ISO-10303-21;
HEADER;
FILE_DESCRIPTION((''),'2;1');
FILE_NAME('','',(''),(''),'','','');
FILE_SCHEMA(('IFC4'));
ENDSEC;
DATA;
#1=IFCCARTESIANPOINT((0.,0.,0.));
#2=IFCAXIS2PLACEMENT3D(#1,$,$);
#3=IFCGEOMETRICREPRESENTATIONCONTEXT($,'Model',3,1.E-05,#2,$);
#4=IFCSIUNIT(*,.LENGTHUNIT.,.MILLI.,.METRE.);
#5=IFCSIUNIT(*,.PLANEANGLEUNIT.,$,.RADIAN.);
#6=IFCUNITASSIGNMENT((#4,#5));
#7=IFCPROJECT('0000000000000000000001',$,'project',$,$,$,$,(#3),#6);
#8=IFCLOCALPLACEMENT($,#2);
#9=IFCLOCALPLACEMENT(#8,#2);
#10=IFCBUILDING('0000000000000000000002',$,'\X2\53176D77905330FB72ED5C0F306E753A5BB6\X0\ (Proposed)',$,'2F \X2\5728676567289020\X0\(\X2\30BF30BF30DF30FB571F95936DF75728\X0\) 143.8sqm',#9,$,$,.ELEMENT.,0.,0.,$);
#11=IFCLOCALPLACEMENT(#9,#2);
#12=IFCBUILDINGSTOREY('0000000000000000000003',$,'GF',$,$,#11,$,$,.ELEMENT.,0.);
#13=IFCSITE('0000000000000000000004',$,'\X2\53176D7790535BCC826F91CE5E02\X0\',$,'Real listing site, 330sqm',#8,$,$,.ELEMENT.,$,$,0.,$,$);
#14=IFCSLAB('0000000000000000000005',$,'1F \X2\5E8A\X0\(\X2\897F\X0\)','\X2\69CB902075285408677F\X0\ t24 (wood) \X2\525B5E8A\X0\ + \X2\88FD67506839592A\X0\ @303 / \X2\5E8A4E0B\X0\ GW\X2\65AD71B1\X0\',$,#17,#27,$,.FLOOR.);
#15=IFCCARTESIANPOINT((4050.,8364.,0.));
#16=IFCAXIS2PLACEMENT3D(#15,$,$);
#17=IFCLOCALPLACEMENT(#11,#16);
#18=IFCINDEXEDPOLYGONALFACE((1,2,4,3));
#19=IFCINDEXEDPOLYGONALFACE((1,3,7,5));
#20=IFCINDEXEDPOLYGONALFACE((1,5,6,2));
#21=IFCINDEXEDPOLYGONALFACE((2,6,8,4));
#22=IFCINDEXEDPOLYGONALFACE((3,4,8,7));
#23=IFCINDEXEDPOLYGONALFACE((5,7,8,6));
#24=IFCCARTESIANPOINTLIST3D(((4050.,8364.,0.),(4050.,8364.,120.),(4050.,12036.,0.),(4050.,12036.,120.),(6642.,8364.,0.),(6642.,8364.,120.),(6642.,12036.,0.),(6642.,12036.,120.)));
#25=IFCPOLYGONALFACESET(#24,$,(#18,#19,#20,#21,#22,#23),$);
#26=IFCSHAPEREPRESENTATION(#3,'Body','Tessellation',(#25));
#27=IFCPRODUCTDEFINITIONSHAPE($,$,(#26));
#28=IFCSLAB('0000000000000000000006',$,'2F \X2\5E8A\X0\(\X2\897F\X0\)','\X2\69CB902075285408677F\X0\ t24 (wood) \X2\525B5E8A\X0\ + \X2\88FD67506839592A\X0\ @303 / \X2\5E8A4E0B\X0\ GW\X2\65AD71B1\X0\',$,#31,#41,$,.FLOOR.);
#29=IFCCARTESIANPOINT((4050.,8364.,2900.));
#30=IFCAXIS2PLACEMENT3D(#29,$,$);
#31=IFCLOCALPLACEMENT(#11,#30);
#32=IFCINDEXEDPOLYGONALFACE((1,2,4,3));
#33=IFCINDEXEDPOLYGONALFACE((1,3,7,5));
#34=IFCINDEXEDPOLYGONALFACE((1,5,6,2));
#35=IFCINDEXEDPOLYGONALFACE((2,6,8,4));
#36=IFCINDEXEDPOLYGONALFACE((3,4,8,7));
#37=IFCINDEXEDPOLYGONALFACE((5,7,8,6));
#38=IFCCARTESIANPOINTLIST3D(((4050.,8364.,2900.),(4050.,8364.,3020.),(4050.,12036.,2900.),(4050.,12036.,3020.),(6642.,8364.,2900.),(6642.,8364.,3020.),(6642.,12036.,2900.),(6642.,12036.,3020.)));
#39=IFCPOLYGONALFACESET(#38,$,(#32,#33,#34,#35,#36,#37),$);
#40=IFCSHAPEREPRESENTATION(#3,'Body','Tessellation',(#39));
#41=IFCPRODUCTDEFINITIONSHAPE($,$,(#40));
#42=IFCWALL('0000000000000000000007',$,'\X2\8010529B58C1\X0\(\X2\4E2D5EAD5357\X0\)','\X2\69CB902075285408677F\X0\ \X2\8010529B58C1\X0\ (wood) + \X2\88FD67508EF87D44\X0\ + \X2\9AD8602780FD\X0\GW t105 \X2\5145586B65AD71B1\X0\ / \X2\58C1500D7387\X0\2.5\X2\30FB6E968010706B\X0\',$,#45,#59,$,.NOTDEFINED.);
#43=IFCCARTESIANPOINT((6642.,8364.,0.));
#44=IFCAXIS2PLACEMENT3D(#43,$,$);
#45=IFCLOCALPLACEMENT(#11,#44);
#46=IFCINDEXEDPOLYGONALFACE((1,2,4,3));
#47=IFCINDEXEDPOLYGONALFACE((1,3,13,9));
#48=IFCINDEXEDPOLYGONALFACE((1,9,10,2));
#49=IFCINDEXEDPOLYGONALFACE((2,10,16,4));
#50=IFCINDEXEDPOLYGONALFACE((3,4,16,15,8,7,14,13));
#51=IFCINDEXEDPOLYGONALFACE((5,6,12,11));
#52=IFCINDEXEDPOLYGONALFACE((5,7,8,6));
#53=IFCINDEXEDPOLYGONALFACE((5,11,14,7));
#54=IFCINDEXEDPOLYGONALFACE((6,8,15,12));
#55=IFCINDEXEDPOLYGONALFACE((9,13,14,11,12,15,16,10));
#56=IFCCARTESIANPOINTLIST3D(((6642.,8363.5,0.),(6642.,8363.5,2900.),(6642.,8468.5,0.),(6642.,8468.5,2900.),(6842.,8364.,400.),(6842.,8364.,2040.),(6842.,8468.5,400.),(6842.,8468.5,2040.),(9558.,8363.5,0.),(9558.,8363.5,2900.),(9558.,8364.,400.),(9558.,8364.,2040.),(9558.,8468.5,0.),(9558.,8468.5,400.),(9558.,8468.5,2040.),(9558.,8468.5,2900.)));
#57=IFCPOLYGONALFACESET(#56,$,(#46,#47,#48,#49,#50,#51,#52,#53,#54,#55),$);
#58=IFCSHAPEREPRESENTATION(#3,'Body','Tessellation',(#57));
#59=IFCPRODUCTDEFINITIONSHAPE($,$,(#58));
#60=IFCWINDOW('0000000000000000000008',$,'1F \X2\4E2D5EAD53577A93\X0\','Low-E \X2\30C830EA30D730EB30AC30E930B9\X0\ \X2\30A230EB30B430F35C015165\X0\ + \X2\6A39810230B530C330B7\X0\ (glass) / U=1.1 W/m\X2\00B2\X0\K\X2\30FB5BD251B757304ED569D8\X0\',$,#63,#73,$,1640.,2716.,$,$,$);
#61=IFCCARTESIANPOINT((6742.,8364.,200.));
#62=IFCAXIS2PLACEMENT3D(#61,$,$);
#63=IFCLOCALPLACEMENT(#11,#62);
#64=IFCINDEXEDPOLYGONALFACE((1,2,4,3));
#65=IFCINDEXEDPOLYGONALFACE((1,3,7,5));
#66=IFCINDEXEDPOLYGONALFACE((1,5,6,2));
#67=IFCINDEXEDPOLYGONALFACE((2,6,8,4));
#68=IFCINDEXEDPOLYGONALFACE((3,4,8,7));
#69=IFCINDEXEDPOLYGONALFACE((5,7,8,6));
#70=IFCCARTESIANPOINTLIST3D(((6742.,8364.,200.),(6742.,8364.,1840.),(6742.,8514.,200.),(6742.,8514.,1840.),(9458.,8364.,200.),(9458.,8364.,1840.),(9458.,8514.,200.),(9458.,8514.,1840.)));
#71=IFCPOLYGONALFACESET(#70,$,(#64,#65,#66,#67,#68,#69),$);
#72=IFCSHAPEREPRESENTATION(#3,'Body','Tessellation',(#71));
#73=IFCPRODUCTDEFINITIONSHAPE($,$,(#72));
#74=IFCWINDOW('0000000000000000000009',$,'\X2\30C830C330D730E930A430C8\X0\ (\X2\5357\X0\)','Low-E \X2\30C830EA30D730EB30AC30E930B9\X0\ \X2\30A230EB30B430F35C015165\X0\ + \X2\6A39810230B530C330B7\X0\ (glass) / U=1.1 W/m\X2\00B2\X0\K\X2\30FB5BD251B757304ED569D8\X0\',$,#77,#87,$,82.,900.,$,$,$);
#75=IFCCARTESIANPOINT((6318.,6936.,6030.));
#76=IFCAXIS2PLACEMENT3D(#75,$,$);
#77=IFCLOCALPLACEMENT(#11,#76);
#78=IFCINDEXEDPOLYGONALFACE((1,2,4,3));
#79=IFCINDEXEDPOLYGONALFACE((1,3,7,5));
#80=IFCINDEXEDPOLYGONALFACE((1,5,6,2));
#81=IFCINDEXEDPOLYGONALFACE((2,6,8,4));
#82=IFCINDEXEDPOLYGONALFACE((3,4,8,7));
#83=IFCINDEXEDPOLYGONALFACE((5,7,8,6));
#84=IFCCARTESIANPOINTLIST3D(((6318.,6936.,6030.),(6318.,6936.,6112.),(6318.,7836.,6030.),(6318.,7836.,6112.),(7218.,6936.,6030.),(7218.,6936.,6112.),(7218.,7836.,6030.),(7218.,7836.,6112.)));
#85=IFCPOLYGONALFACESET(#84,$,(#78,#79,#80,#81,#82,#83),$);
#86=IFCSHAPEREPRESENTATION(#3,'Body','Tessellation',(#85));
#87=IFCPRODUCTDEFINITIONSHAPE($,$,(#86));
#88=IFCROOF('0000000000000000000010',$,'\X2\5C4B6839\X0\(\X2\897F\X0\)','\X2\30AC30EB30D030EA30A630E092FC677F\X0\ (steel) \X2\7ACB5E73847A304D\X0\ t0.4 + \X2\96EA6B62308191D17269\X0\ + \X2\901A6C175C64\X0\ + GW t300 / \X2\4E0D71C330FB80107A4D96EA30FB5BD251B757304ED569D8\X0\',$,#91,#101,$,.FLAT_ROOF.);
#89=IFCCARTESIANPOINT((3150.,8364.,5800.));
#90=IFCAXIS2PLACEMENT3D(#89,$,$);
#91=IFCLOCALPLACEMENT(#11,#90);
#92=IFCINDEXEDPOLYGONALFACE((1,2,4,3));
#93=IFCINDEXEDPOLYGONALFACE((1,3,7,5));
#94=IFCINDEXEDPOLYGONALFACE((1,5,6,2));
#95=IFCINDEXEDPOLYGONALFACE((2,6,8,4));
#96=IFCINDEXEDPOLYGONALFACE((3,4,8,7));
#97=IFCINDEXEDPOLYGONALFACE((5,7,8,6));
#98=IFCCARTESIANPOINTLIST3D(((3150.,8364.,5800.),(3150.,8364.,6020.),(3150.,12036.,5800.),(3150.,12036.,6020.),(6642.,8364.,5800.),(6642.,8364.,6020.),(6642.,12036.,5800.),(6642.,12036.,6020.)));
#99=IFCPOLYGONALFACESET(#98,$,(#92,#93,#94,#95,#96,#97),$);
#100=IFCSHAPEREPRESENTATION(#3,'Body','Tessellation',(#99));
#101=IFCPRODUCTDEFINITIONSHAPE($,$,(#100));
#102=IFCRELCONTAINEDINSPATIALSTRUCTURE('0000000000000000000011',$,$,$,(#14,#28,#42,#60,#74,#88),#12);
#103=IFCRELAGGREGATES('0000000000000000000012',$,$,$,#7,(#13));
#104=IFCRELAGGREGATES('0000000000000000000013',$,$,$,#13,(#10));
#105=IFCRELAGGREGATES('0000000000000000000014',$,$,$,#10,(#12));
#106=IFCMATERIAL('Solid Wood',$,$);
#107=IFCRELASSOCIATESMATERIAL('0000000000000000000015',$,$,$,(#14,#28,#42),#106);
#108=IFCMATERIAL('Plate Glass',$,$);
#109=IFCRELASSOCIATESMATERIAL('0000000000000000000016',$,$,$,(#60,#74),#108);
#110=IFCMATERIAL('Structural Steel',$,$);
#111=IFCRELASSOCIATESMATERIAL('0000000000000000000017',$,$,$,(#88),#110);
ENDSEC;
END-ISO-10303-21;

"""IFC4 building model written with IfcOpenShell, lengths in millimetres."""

from ifc_helpers import new_model, si_unit, frame, frame_2d, origin, place, context, project, spatial, rectangle, extrude, material, element, fill, save


model = new_model("IFC4")

# Units and contexts
model_context = context("Model", 3, precision=1e-05, world=origin())
ifc_project = project(units=[si_unit("LENGTHUNIT", "METRE", prefix="MILLI"), si_unit("PLANEANGLEUNIT", "RADIAN")], contexts=[model_context])

# Site, building, storey
site_placement = place(None, origin())
site = spatial("IfcSite", under=ifc_project, at=site_placement, Name="北海道富良野市", ObjectType="Real listing site, 330sqm", CompositionType="ELEMENT", RefElevation=0.0)
building_placement = place(site_placement, origin())
building = spatial("IfcBuilding", under=site, at=building_placement, Name="北海道・狭小の町家 (Proposed)", ObjectType="2F 在来木造(タタミ・土間混在) 143.8sqm", CompositionType="ELEMENT", ElevationOfRefHeight=0.0, ElevationOfTerrain=0.0)
storey_placement = place(building_placement, origin())
storey = spatial("IfcBuildingStorey", under=building, at=storey_placement, Name="GF", CompositionType="ELEMENT", Elevation=0.0)

# Shared definitions
ifc_material_1 = material(Name="Solid Wood")

# Slabs
slab_1_placement = place(storey_placement, frame((4050.0, 8364.0, 0.0)))
element("IfcSlab", 1, at=slab_1_placement, inside=storey, material=ifc_material_1, Name="1F 床(西)", Description="構造用合板 t24 (wood) 剛床 + 製材根太 @303 / 床下 GW断熱", PredefinedType="FLOOR", context=model_context, shape_type="SweptSolid", body=[
    extrude(rectangle(XDim=2592.0, YDim=3672.0, at=frame_2d((1296.0, 1836.0))), frame((4050.0, 8364.0, 0.0)), (0.0, 0.0, 1.0), 120.0),
])
slab_2_placement = place(storey_placement, frame((4050.0, 8364.0, 2900.0)))
element("IfcSlab", 2, at=slab_2_placement, inside=storey, material=ifc_material_1, Name="2F 床(西)", Description="構造用合板 t24 (wood) 剛床 + 製材根太 @303 / 床下 GW断熱", PredefinedType="FLOOR", context=model_context, shape_type="SweptSolid", body=[
    extrude(rectangle(XDim=2592.0, YDim=3672.0, at=frame_2d((1296.0, 1836.0))), frame((4050.0, 8364.0, 2900.0)), (0.0, 0.0, 1.0), 120.0),
])

# Wall, opening, window
wall_placement = place(storey_placement, frame((6642.0, 8364.0, 0.0)))
wall = element("IfcWall", 3, at=wall_placement, inside=storey, material=ifc_material_1, Name="耐力壁(中庭南)", Description="構造用合板 耐力壁 (wood) + 製材軸組 + 高性能GW t105 充填断熱 / 壁倍率2.5・準耐火", PredefinedType="NOTDEFINED", context=model_context, shape_type="SweptSolid", body=[
    extrude(rectangle(XDim=2916.0, YDim=105.0, at=frame_2d((1458.0, 52.0))), frame((6642.0, 8364.0, 0.0)), (0.0, 0.0, 1.0), 2900.0),
])
opening_placement = place(storey_placement, frame((6742.0, 8364.0, 200.0)))
opening = element("IfcOpeningElement", 4, at=opening_placement, cuts=wall, PredefinedType="NOTDEFINED", context=model_context, shape_type="SweptSolid", body=[
    extrude(rectangle(XDim=2716.0, YDim=150.0, at=frame_2d((1358.0, 75.0))), frame((6742.0, 8364.0, 200.0)), (0.0, 0.0, 1.0), 1640.0),
])
ifc_material_2 = material(Name="Plate Glass")
window_1_placement = place(storey_placement, frame((6742.0, 8364.0, 200.0)))
window_1 = element("IfcWindow", 5, at=window_1_placement, inside=storey, material=ifc_material_2, Name="1F 中庭南窓", Description="Low-E トリプルガラス アルゴン封入 + 樹脂サッシ (glass) / U=1.1 W/m²K・寒冷地仕様", OverallHeight=1640.0, OverallWidth=2716.0, context=model_context, shape_type="SweptSolid", body=[
    extrude(rectangle(XDim=2716.0, YDim=150.0, at=frame_2d((1358.0, 75.0))), frame((6742.0, 8364.0, 200.0)), (0.0, 0.0, 1.0), 1640.0),
])
fill(opening, window_1)

# Window
window_2_placement = place(storey_placement, frame((6318.0, 6936.0, 6030.0)))
element("IfcWindow", 6, at=window_2_placement, inside=storey, material=ifc_material_2, Name="トップライト (南)", Description="Low-E トリプルガラス アルゴン封入 + 樹脂サッシ (glass) / U=1.1 W/m²K・寒冷地仕様", OverallHeight=82.0, OverallWidth=900.0, context=model_context, shape_type="SweptSolid", body=[
    extrude(rectangle(XDim=900.0, YDim=900.0, at=frame_2d((450.0, 450.0))), frame((6318.0, 6936.0, 6030.0)), (0.0, 0.0, 1.0), 82.0),
])

# Roof
ifc_material_3 = material(Name="Structural Steel")
for number, where, name in (
    (7, (3150.0, 8364.0, 5800.0), "屋根(西)"),
):
    element("IfcRoof", number, at=place(storey_placement, frame(where)), inside=storey, material=ifc_material_3, Name=name, Description="ガルバリウム鋼板 (steel) 立平葺き t0.4 + 雪止め金物 + 通気層 + GW t300 / 不燃・耐積雪・寒冷地仕様", PredefinedType="FLAT_ROOF", context=model_context, shape_type="SweptSolid", body=[
        extrude(rectangle(XDim=3492.0, YDim=3672.0, at=frame_2d((1746.0, 1836.0))), frame((3150.0, 8364.0, 5800.0)), (0.0, 0.0, 1.0), 220.0),
    ])

save(model, "model.ifc")
